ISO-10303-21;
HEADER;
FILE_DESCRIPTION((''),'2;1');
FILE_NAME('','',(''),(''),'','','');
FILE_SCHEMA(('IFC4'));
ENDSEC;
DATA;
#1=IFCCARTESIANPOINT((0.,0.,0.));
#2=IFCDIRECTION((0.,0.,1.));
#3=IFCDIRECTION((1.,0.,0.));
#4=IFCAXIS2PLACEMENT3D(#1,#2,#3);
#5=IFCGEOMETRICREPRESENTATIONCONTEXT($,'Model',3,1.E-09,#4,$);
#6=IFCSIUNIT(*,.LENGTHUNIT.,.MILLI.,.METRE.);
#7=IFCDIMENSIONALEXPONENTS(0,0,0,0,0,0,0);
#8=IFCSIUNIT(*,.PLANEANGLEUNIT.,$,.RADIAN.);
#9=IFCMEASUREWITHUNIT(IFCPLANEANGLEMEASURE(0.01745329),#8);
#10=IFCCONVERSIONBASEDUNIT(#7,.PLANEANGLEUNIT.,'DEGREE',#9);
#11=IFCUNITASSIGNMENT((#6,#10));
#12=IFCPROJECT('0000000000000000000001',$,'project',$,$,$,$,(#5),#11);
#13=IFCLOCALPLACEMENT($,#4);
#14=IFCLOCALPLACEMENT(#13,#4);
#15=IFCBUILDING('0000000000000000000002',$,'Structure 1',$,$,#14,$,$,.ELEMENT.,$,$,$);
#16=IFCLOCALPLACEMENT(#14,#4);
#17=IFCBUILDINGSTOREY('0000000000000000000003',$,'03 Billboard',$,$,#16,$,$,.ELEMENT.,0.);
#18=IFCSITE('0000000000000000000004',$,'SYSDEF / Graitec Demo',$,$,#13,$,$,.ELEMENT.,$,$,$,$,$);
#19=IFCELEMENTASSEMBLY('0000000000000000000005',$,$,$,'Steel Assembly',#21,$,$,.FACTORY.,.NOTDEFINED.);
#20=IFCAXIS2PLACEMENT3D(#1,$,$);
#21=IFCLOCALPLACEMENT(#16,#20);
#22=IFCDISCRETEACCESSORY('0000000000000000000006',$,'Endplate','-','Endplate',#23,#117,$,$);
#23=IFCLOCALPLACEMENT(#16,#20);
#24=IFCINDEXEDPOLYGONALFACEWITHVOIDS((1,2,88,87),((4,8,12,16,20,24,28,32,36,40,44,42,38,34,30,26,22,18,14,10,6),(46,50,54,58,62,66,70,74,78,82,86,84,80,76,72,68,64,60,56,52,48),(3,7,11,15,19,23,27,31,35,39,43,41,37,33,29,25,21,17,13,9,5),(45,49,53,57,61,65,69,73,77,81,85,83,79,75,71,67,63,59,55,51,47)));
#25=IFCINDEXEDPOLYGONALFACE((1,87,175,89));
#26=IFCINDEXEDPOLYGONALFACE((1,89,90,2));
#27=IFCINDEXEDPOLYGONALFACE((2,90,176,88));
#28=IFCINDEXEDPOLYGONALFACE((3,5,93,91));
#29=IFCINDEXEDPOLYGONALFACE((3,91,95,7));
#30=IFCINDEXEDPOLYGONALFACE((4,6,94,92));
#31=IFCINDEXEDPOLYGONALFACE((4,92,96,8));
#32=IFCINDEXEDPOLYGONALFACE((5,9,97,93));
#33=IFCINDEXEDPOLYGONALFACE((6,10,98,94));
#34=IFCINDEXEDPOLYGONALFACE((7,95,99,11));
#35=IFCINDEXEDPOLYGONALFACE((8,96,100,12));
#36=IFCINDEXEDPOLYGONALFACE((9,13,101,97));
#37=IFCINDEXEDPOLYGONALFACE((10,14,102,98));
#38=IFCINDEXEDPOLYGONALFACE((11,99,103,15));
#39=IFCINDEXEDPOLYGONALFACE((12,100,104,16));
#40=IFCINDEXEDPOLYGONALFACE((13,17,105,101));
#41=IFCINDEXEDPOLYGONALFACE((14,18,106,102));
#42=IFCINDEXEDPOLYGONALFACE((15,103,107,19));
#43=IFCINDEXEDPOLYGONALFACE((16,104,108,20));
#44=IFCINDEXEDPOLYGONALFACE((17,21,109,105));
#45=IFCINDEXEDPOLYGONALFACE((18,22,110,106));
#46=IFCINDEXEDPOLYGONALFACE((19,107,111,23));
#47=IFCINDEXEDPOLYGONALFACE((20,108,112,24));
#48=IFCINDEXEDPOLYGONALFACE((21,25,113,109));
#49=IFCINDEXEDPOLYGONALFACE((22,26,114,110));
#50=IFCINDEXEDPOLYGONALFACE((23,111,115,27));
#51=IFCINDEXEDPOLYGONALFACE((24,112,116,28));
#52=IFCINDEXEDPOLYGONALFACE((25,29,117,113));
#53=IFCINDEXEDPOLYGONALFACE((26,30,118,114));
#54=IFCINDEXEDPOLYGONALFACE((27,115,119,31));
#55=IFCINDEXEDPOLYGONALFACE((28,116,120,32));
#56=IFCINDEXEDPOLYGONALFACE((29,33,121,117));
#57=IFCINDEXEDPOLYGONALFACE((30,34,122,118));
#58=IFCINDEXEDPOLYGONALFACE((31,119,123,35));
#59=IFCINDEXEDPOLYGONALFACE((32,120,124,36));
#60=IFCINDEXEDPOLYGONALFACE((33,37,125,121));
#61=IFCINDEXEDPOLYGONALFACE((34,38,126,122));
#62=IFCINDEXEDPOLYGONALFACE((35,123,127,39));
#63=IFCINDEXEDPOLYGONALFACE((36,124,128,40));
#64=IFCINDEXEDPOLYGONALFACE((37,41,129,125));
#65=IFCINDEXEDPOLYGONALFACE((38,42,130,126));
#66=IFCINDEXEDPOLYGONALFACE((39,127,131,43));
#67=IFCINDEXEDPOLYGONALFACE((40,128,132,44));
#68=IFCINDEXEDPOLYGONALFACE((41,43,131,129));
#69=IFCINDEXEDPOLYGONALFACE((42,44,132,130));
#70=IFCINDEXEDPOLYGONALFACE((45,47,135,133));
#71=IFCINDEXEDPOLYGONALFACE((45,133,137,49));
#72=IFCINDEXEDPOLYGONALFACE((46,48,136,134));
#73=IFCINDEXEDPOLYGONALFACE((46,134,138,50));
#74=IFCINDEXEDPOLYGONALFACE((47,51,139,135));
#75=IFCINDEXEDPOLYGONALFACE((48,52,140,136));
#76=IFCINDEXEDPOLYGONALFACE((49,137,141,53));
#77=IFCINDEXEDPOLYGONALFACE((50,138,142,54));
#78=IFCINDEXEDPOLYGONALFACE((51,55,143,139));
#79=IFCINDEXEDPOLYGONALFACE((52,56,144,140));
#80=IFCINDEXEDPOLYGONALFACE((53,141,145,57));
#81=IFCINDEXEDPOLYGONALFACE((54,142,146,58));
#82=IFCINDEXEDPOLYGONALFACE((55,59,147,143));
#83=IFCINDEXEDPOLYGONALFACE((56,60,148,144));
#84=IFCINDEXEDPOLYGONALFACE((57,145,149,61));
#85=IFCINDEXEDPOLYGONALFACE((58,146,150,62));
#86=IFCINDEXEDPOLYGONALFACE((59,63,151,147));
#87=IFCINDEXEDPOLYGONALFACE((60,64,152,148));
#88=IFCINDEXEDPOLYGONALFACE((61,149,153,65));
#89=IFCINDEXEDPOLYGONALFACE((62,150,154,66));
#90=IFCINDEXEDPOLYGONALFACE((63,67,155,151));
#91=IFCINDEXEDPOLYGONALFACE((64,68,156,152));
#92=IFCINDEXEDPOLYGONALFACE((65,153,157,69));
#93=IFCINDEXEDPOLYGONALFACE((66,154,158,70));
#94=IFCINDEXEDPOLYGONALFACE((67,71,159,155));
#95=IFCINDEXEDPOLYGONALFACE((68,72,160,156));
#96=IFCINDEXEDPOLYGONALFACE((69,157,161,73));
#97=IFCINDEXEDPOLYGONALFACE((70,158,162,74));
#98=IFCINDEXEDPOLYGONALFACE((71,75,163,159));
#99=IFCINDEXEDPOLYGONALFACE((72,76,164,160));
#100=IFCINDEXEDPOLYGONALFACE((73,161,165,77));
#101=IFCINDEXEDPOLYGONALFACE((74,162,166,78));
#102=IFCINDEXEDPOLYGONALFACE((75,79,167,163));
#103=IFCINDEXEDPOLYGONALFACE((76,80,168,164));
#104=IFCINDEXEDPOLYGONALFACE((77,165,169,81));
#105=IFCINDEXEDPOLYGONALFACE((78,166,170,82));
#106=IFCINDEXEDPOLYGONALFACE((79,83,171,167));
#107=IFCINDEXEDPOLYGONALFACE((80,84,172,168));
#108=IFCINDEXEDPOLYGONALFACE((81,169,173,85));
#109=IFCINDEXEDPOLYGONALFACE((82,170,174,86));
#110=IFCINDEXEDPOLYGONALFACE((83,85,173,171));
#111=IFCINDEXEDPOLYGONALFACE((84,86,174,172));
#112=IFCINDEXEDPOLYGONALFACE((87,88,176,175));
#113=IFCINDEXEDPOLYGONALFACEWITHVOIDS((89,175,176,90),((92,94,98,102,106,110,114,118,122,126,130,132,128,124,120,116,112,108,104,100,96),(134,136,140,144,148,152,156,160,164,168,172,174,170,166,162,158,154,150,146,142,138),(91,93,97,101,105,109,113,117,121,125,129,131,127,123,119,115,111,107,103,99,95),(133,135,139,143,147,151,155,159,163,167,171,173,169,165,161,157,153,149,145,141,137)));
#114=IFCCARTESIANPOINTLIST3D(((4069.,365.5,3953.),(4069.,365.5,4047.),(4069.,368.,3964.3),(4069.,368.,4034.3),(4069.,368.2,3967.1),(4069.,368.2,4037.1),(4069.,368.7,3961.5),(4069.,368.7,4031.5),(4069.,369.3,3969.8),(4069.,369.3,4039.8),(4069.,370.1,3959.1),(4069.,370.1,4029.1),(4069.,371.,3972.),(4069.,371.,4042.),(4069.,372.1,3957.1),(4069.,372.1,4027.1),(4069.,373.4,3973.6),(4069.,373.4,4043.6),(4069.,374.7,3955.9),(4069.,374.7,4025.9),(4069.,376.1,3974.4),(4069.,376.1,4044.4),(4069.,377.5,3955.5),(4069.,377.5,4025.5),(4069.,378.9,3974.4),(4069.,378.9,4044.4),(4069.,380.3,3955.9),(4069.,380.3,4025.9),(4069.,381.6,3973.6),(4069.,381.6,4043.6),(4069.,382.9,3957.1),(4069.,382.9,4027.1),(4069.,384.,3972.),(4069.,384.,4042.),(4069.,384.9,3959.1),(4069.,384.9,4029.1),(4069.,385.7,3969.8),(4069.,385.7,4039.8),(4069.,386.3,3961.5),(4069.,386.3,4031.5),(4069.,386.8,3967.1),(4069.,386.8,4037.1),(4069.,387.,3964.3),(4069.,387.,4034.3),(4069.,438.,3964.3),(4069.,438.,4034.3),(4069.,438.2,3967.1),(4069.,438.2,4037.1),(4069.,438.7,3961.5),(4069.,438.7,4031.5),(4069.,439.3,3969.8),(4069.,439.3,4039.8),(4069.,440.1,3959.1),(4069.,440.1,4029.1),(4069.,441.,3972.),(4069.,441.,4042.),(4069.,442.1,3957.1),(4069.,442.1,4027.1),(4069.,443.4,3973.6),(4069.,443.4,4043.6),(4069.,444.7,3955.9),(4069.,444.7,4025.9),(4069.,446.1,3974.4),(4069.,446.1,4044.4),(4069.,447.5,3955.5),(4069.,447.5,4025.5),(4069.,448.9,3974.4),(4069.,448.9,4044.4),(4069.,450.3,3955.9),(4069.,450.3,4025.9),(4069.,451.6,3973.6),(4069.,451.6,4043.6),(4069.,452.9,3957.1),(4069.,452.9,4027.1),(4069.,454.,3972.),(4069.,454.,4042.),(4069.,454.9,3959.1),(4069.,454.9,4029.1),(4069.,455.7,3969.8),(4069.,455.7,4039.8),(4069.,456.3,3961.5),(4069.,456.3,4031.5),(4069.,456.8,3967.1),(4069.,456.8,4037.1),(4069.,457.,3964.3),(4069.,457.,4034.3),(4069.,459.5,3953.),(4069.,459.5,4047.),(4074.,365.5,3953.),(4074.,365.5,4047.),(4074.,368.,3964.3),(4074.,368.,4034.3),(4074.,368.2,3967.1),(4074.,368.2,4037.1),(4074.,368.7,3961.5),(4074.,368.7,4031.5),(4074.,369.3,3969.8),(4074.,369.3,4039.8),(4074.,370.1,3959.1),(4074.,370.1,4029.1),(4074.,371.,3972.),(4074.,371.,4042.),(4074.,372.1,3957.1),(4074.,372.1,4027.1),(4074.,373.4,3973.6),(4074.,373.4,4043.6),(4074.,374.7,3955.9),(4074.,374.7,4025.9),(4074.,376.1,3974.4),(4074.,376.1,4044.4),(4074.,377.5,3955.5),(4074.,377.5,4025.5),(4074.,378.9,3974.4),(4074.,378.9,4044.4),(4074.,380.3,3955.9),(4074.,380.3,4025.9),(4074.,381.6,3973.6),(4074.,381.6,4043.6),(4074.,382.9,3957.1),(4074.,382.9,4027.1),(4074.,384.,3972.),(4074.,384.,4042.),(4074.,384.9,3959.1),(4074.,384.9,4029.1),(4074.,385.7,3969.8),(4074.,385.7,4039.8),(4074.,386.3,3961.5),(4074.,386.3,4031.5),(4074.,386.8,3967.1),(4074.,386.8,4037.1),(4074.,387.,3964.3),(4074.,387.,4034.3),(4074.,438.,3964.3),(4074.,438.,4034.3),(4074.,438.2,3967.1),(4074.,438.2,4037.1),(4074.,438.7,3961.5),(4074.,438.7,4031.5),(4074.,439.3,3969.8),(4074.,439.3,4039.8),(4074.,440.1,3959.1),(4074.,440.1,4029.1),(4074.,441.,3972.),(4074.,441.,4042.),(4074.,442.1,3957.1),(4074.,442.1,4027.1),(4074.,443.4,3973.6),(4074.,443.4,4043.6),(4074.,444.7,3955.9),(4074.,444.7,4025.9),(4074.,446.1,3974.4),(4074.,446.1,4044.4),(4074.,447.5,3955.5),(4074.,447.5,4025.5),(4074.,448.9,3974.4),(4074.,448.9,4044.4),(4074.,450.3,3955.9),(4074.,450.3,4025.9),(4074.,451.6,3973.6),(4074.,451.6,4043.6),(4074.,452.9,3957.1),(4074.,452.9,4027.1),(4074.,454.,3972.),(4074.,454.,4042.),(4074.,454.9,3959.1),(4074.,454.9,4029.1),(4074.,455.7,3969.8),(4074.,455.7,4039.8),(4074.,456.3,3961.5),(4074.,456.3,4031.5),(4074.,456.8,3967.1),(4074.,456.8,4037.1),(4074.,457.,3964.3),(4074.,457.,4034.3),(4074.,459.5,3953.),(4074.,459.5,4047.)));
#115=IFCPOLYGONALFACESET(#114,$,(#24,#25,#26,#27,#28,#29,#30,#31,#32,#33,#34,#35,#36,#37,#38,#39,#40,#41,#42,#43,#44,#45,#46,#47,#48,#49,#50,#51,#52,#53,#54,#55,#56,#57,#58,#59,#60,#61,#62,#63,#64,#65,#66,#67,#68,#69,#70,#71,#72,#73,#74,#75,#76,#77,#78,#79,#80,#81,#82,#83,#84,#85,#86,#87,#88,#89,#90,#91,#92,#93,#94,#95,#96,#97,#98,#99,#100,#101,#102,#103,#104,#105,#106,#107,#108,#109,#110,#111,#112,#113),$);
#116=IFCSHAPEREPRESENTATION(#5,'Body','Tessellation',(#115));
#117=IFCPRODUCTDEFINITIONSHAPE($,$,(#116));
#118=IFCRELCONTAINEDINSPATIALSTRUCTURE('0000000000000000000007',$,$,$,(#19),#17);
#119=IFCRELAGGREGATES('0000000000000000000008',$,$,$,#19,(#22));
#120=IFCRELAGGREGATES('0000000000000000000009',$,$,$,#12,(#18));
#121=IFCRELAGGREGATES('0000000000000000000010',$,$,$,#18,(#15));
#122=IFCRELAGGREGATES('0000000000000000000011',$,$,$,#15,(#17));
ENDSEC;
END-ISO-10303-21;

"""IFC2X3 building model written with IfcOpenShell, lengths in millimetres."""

from ifc_helpers import new_model, entity, si_unit, converted_unit, frame, frame_2d, origin, origin_with_axes, place, context, project, spatial, polyline, circle, outline, extrude, element, aggregate, save


model = new_model("IFC2X3")

# Units and contexts
model_context = context("Model", 3, precision=1e-09, world=origin_with_axes())
ifc_project = project(units=[si_unit("LENGTHUNIT", "METRE", prefix="MILLI"), converted_unit("PLANEANGLEUNIT", "DEGREE", entity("IfcPlaneAngleMeasure", 0.01745329), si_unit("PLANEANGLEUNIT", "RADIAN"), dimensions=[0, 0, 0, 0, 0, 0, 0])], contexts=[model_context])

# Site, building, storey
site_placement = place(None, origin_with_axes())
site = spatial("IfcSite", under=ifc_project, at=site_placement, Name="SYSDEF / Graitec Demo", CompositionType="ELEMENT")
building_placement = place(site_placement, origin_with_axes())
building = spatial("IfcBuilding", under=site, at=building_placement, Name="Structure 1", CompositionType="ELEMENT")
storey_placement = place(building_placement, origin_with_axes())
storey = spatial("IfcBuildingStorey", under=building, at=storey_placement, Name="03 Billboard", CompositionType="ELEMENT", Elevation=0.0)

# Element assembly, discrete accessory, openings
assembly_1_placement = place(None, frame((-4239.1, -387.5, 4000.0), z_axis=(-1.0, 0.0, 0.0), x_axis=(0.0, 0.0, 1.0)))
assembly_1 = element("IfcElementAssembly", 1, at=assembly_1_placement, inside=storey, ObjectType="Steel Assembly", AssemblyPlace="FACTORY", PredefinedType="NOTDEFINED")
discrete_accessory_1_placement = place(assembly_1_placement, frame((47.0, 847.0, -8308.1), z_axis=(0.0, 0.0, -1.0), x_axis=(0.0, -1.0, 0.0)))
discrete_accessory_1 = element("IfcDiscreteAccessory", 2, at=discrete_accessory_1_placement, Name="Endplate", Description="-", ObjectType="Endplate", context=model_context, shape_type="SweptSolid", body=[
    extrude(outline(polyline([(0.0, 0.0), (94.0, 0.0), (94.0, 94.0), (0.0, 94.0), (0.0, 0.0)])), origin_with_axes(), (0.0, 0.0, 1.0), 5.0),
])
opening_1_placement = place(discrete_accessory_1_placement, frame((47.0, 47.0, -0.5), z_axis=(0.0, 0.0, 1.0), x_axis=(0.0, 1.0, 0.0)))
element("IfcOpeningElement", 3, at=opening_1_placement, cuts=discrete_accessory_1, ObjectType="Opening", context=model_context, shape_type="SweptSolid", body=[
    extrude(circle(Radius=9.5, at=frame_2d((35.0, 35.0), x_axis=(1.0, 0.0))), origin(), (0.0, 0.0, 1.0), 6.0),
])
opening_2_placement = place(discrete_accessory_1_placement, frame((47.0, 47.0, -0.5), z_axis=(0.0, 0.0, 1.0), x_axis=(0.0, 1.0, 0.0)))
element("IfcOpeningElement", 4, at=opening_2_placement, cuts=discrete_accessory_1, ObjectType="Opening", context=model_context, shape_type="SweptSolid", body=[
    extrude(circle(Radius=9.5, at=frame_2d((-35.0, 35.0), x_axis=(1.0, 0.0))), origin(), (0.0, 0.0, 1.0), 6.0),
])
opening_3_placement = place(discrete_accessory_1_placement, frame((47.0, 47.0, -0.5), z_axis=(0.0, 0.0, 1.0), x_axis=(0.0, 1.0, 0.0)))
element("IfcOpeningElement", 5, at=opening_3_placement, cuts=discrete_accessory_1, ObjectType="Opening", context=model_context, shape_type="SweptSolid", body=[
    extrude(circle(Radius=9.5, at=frame_2d((35.0, -35.0), x_axis=(1.0, 0.0))), origin(), (0.0, 0.0, 1.0), 6.0),
])
opening_4_placement = place(discrete_accessory_1_placement, frame((47.0, 47.0, -0.5), z_axis=(0.0, 0.0, 1.0), x_axis=(0.0, 1.0, 0.0)))
element("IfcOpeningElement", 6, at=opening_4_placement, cuts=discrete_accessory_1, ObjectType="Opening", context=model_context, shape_type="SweptSolid", body=[
    extrude(circle(Radius=9.5, at=frame_2d((-35.0, -35.0), x_axis=(1.0, 0.0))), origin(), (0.0, 0.0, 1.0), 6.0),
])
aggregate(assembly_1, [discrete_accessory_1])

save(model, "model.ifc")
